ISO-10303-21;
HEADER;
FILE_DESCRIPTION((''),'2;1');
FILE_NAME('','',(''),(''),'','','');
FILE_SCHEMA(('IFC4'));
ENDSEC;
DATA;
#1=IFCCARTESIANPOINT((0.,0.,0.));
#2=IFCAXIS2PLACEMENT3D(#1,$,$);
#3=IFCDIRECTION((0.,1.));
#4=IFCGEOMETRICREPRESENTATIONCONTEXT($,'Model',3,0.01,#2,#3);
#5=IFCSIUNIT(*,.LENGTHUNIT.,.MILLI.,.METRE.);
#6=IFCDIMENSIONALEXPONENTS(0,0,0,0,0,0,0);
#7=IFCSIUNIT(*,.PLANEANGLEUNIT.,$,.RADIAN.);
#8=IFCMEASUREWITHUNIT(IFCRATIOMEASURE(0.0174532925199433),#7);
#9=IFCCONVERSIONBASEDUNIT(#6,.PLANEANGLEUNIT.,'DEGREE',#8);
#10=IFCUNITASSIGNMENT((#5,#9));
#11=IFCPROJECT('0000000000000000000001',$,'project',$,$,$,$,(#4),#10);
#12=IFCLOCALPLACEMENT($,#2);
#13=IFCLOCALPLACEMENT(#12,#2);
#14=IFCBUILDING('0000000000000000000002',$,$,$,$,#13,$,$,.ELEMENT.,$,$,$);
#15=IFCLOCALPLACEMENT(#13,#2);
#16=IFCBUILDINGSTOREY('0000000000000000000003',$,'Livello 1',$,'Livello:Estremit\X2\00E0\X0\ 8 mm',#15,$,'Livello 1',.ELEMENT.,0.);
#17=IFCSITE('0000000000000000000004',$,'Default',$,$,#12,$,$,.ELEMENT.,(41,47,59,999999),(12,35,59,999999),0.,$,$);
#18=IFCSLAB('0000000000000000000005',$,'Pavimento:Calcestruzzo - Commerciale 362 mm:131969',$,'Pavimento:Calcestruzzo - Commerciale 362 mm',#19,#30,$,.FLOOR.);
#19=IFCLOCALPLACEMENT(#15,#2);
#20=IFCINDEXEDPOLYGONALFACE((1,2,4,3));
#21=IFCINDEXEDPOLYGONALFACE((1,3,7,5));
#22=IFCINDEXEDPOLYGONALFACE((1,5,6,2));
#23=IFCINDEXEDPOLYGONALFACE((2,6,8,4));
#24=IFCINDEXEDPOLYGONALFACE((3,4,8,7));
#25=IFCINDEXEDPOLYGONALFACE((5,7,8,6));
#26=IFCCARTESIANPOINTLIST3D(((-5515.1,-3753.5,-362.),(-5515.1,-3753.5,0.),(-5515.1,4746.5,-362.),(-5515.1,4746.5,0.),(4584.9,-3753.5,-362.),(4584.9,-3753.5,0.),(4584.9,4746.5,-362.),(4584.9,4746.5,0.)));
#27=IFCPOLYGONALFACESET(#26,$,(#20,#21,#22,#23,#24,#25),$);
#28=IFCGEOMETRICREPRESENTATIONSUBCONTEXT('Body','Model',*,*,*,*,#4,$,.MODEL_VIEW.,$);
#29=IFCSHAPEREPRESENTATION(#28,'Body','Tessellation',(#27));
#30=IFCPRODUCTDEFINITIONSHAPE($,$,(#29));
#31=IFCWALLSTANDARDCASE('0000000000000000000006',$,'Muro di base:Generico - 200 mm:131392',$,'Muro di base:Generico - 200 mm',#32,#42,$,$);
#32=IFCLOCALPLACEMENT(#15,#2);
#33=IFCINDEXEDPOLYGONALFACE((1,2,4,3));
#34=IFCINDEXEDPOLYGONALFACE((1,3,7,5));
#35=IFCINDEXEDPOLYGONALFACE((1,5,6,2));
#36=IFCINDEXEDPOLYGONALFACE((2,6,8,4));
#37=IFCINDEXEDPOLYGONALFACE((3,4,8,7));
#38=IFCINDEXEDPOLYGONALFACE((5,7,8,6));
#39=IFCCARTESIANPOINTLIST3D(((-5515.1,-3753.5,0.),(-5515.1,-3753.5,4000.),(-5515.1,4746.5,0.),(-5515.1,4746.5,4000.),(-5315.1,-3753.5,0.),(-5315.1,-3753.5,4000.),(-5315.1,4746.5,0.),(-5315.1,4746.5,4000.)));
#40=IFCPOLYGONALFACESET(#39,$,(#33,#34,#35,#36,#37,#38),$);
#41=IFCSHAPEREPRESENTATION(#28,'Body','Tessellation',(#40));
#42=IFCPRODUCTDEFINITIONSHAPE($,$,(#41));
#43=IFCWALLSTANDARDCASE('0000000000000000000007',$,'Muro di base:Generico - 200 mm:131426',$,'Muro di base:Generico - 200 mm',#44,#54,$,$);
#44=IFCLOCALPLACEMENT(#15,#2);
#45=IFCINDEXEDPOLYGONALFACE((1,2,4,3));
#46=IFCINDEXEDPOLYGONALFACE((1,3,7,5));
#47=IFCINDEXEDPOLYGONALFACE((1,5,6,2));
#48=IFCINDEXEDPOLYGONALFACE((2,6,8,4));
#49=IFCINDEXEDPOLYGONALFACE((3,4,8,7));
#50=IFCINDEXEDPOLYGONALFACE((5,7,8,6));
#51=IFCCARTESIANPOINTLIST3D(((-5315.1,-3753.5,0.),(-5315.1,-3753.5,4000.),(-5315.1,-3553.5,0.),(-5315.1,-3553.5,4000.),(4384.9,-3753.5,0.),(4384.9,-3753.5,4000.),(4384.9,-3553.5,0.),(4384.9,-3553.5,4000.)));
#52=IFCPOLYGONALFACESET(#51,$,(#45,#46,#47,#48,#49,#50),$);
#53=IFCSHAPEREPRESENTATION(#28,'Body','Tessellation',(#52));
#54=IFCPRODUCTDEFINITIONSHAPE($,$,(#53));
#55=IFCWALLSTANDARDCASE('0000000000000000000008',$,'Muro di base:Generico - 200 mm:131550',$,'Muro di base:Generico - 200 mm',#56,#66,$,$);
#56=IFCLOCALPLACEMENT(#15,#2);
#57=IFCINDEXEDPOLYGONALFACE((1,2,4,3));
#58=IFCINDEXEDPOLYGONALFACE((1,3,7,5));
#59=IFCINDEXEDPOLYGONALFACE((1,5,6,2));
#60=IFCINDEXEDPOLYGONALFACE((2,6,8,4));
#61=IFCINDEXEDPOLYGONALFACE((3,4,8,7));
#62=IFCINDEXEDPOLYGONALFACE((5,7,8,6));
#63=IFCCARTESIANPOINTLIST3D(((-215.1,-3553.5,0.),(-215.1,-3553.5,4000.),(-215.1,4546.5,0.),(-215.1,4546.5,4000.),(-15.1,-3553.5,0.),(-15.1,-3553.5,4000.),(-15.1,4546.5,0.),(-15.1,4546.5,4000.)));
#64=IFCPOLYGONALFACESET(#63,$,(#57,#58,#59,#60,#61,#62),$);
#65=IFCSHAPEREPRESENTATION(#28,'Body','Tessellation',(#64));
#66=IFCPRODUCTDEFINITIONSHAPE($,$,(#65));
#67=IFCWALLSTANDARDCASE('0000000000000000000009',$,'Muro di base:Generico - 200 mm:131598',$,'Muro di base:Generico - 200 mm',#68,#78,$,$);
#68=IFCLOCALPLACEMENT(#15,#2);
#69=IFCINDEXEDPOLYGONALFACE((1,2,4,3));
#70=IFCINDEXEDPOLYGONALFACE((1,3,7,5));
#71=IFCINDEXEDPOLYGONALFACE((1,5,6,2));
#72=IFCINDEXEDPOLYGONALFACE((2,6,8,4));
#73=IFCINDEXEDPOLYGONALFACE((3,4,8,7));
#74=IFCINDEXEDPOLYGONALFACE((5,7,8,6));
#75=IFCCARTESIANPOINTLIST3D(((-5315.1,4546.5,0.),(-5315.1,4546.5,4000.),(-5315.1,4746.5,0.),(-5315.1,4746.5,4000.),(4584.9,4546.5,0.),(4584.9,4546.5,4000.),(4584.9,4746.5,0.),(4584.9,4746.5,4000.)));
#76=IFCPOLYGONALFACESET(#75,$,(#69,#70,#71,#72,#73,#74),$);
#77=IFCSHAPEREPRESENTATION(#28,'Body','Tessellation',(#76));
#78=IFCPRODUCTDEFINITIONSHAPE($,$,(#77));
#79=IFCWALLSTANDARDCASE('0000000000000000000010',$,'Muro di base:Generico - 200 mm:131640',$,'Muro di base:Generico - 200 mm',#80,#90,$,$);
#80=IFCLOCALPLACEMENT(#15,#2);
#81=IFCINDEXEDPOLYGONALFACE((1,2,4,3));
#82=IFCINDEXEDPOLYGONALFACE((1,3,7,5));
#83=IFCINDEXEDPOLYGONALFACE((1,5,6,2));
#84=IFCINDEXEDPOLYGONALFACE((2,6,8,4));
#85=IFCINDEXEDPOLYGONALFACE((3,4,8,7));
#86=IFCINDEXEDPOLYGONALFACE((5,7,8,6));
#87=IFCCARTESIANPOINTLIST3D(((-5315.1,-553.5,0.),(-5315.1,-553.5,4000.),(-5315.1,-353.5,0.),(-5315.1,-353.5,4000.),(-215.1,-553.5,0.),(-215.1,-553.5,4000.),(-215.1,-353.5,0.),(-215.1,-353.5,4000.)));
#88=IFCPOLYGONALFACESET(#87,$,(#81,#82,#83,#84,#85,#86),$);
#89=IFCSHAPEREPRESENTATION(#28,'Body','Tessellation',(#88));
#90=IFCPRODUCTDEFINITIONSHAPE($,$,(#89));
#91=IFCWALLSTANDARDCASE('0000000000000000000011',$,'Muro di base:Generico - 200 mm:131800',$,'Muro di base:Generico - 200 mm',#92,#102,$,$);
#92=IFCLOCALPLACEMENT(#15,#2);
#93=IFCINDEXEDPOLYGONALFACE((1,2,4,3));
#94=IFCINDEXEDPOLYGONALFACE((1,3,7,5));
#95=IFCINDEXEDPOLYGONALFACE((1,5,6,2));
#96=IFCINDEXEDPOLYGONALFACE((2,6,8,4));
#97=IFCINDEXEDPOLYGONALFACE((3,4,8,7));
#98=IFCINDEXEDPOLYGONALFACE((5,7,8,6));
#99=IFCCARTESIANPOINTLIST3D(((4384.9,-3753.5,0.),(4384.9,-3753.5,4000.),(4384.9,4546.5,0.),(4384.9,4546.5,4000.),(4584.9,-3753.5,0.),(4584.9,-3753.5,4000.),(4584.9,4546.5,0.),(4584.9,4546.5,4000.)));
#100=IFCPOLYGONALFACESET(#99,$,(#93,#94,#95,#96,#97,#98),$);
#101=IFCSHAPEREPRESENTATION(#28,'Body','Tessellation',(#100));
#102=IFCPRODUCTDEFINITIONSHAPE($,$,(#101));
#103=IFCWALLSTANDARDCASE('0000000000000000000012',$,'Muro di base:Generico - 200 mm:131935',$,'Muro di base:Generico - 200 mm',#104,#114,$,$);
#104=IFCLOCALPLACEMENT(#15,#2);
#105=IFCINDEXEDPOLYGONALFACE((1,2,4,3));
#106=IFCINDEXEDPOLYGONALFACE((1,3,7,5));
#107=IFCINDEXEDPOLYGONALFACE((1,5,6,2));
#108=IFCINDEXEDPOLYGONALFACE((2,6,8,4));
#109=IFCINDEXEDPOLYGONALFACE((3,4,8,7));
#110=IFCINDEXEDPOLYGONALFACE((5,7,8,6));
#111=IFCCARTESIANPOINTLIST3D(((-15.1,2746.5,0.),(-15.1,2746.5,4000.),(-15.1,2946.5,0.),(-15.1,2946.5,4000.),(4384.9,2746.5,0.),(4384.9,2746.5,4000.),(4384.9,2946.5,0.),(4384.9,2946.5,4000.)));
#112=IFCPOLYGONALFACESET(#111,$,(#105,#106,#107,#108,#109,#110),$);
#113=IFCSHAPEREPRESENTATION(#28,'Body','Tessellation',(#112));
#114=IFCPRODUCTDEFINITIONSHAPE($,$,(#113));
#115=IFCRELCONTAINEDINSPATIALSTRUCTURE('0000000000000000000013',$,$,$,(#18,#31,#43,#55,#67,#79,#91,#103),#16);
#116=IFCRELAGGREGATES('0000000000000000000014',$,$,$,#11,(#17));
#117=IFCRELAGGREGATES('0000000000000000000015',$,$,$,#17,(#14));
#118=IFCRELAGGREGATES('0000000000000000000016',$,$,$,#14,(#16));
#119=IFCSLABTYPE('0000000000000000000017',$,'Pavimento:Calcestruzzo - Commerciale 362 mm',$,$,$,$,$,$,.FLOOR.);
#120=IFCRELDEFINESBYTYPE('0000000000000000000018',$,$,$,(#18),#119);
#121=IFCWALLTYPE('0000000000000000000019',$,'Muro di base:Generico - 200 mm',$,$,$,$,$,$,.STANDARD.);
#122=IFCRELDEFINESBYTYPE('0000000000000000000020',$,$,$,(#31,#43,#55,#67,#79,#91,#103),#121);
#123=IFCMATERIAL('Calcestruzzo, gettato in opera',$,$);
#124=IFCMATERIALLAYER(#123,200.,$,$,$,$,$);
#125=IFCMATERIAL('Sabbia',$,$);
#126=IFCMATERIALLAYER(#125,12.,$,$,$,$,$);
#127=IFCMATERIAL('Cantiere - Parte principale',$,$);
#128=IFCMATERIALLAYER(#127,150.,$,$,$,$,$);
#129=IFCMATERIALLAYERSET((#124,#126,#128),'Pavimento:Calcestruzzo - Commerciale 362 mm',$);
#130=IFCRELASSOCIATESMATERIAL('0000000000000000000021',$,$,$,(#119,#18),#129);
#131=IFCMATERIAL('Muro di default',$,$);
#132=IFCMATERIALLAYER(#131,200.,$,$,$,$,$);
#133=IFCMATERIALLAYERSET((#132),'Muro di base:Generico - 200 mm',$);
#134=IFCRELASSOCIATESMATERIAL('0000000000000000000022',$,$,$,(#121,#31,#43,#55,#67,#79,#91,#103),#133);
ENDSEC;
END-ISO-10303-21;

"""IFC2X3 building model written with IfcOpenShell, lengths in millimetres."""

from ifc_helpers import new_model, entity, si_unit, converted_unit, direction, frame, frame_2d, origin, place, context, subcontext, project, spatial, rectangle, extrude, material, layer, layer_set, layer_usage, type_object, element, save


model = new_model("IFC2X3")

# Units and contexts
model_context = context("Model", 3, precision=0.01, world=origin(), true_north=direction((0.0, 1.0)))
body_context = subcontext(model_context, "Body", "Model", "MODEL_VIEW")
ifc_project = project(units=[si_unit("LENGTHUNIT", "METRE", prefix="MILLI"), converted_unit("PLANEANGLEUNIT", "DEGREE", entity("IfcRatioMeasure", 0.0174532925199433), si_unit("PLANEANGLEUNIT", "RADIAN"), dimensions=[0, 0, 0, 0, 0, 0, 0])], contexts=[model_context])

# Site, building, storey
site_placement = place(None, origin())
site = spatial("IfcSite", under=ifc_project, at=site_placement, Name="Default", CompositionType="ELEMENT", RefLatitude=(41, 47, 59, 999999), RefLongitude=(12, 35, 59, 999999), RefElevation=0.0)
building_placement = place(site_placement, origin())
building = spatial("IfcBuilding", under=site, at=building_placement, CompositionType="ELEMENT")
storey_placement = place(building_placement, origin())
storey = spatial("IfcBuildingStorey", under=building, at=storey_placement, Name="Livello 1", ObjectType="Livello:Estremità 8 mm", LongName="Livello 1", CompositionType="ELEMENT", Elevation=0.0)

# Slab
ifc_material_1 = material(Name="Calcestruzzo, gettato in opera")
ifc_layer_1 = layer(ifc_material_1, 200.0)
ifc_material_2 = material(Name="Sabbia")
ifc_layer_2 = layer(ifc_material_2, 12.0)
ifc_material_3 = material(Name="Cantiere - Parte principale")
ifc_layer_3 = layer(ifc_material_3, 150.0)
ifc_layer_set_1 = layer_set([ifc_layer_1, ifc_layer_2, ifc_layer_3], Name="Pavimento:Calcestruzzo - Commerciale 362 mm")
ifc_layer_usage_1 = layer_usage(ifc_layer_set_1, "AXIS3", "POSITIVE", 0.0)
slab_type = type_object("IfcSlabType", Name="Pavimento:Calcestruzzo - Commerciale 362 mm", PredefinedType="FLOOR", material=ifc_layer_set_1)
slab_placement = place(storey_placement, origin())
element("IfcSlab", 1, at=slab_placement, inside=storey, type_object=slab_type, material=ifc_layer_usage_1, Name="Pavimento:Calcestruzzo - Commerciale 362 mm:131969", ObjectType="Pavimento:Calcestruzzo - Commerciale 362 mm", PredefinedType="FLOOR", context=body_context, shape_type="SweptSolid", body=[
    extrude(rectangle(XDim=8500.0, YDim=10100.0, at=frame_2d((0.0, 0.0), x_axis=(1.0, 0.0))), frame((-465.1, 496.5, 0.0), z_axis=(0.0, 0.0, -1.0), x_axis=(0.0, 1.0, 0.0)), (0.0, 0.0, 1.0), 362.0),
])

# Walls
ifc_material_4 = material(Name="Muro di default")
ifc_layer_4 = layer(ifc_material_4, 200.0)
ifc_layer_set_2 = layer_set([ifc_layer_4], Name="Muro di base:Generico - 200 mm")
ifc_layer_usage_2 = layer_usage(ifc_layer_set_2, "AXIS2", "NEGATIVE", 100.0)
wall_type = type_object("IfcWallType", Name="Muro di base:Generico - 200 mm", PredefinedType="STANDARD", material=ifc_layer_set_2)
wall_1_placement = place(storey_placement, frame((-5415.1, 4746.5, 0.0), z_axis=(0.0, 0.0, 1.0), x_axis=(0.0, -1.0, 0.0)))
element("IfcWallStandardCase", 2, at=wall_1_placement, inside=storey, type_object=wall_type, material=ifc_layer_usage_2, Name="Muro di base:Generico - 200 mm:131392", ObjectType="Muro di base:Generico - 200 mm", context=body_context, shape_type="SweptSolid", body=[
    extrude(rectangle(XDim=8500.0, YDim=200.0, at=frame_2d((4250.0, 0.0), x_axis=(-1.0, 0.0))), origin(), (0.0, 0.0, 1.0), 4000.0),
])
ifc_layer_usage_3 = layer_usage(ifc_layer_set_2, "AXIS2", "NEGATIVE", 100.0)
wall_2_placement = place(storey_placement, frame((-5315.1, -3653.5, 0.0)))
element("IfcWallStandardCase", 3, at=wall_2_placement, inside=storey, type_object=wall_type, material=ifc_layer_usage_3, Name="Muro di base:Generico - 200 mm:131426", ObjectType="Muro di base:Generico - 200 mm", context=body_context, shape_type="SweptSolid", body=[
    extrude(rectangle(XDim=9700.0, YDim=200.0, at=frame_2d((4850.0, 0.0), x_axis=(-1.0, 0.0))), origin(), (0.0, 0.0, 1.0), 4000.0),
])
ifc_layer_usage_4 = layer_usage(ifc_layer_set_2, "AXIS2", "NEGATIVE", 100.0)
wall_3_placement = place(storey_placement, frame((-115.1, -3553.5, 0.0), z_axis=(0.0, 0.0, 1.0), x_axis=(0.0, 1.0, 0.0)))
element("IfcWallStandardCase", 4, at=wall_3_placement, inside=storey, type_object=wall_type, material=ifc_layer_usage_4, Name="Muro di base:Generico - 200 mm:131550", ObjectType="Muro di base:Generico - 200 mm", context=body_context, shape_type="SweptSolid", body=[
    extrude(rectangle(XDim=8100.0, YDim=200.0, at=frame_2d((4050.0, 0.0), x_axis=(-1.0, 0.0))), origin(), (0.0, 0.0, 1.0), 4000.0),
])
ifc_layer_usage_5 = layer_usage(ifc_layer_set_2, "AXIS2", "NEGATIVE", 100.0)
wall_4_placement = place(storey_placement, frame((4584.9, 4646.5, 0.0), z_axis=(0.0, 0.0, 1.0), x_axis=(-1.0, 0.0, 0.0)))
element("IfcWallStandardCase", 5, at=wall_4_placement, inside=storey, type_object=wall_type, material=ifc_layer_usage_5, Name="Muro di base:Generico - 200 mm:131598", ObjectType="Muro di base:Generico - 200 mm", context=body_context, shape_type="SweptSolid", body=[
    extrude(rectangle(XDim=9900.0, YDim=200.0, at=frame_2d((4950.0, 0.0), x_axis=(-1.0, 0.0))), origin(), (0.0, 0.0, 1.0), 4000.0),
])
ifc_layer_usage_6 = layer_usage(ifc_layer_set_2, "AXIS2", "NEGATIVE", 100.0)
wall_5_placement = place(storey_placement, frame((-5315.1, -453.5, 0.0)))
element("IfcWallStandardCase", 6, at=wall_5_placement, inside=storey, type_object=wall_type, material=ifc_layer_usage_6, Name="Muro di base:Generico - 200 mm:131640", ObjectType="Muro di base:Generico - 200 mm", context=body_context, shape_type="SweptSolid", body=[
    extrude(rectangle(XDim=5100.0, YDim=200.0, at=frame_2d((2550.0, 0.0), x_axis=(-1.0, 0.0))), origin(), (0.0, 0.0, 1.0), 4000.0),
])
ifc_layer_usage_7 = layer_usage(ifc_layer_set_2, "AXIS2", "NEGATIVE", 100.0)
wall_6_placement = place(storey_placement, frame((4484.9, 4546.5, 0.0), z_axis=(0.0, 0.0, 1.0), x_axis=(0.0, -1.0, 0.0)))
element("IfcWallStandardCase", 7, at=wall_6_placement, inside=storey, type_object=wall_type, material=ifc_layer_usage_7, Name="Muro di base:Generico - 200 mm:131800", ObjectType="Muro di base:Generico - 200 mm", context=body_context, shape_type="SweptSolid", body=[
    extrude(rectangle(XDim=8300.0, YDim=200.0, at=frame_2d((4150.0, 0.0), x_axis=(-1.0, 0.0))), origin(), (0.0, 0.0, 1.0), 4000.0),
])
ifc_layer_usage_8 = layer_usage(ifc_layer_set_2, "AXIS2", "NEGATIVE", 100.0)
wall_7_placement = place(storey_placement, frame((-15.1, 2846.5, 0.0)))
element("IfcWallStandardCase", 8, at=wall_7_placement, inside=storey, type_object=wall_type, material=ifc_layer_usage_8, Name="Muro di base:Generico - 200 mm:131935", ObjectType="Muro di base:Generico - 200 mm", context=body_context, shape_type="SweptSolid", body=[
    extrude(rectangle(XDim=4400.0, YDim=200.0, at=frame_2d((2200.0, 0.0), x_axis=(-1.0, 0.0))), origin(), (0.0, 0.0, 1.0), 4000.0),
])

save(model, "model.ifc")
